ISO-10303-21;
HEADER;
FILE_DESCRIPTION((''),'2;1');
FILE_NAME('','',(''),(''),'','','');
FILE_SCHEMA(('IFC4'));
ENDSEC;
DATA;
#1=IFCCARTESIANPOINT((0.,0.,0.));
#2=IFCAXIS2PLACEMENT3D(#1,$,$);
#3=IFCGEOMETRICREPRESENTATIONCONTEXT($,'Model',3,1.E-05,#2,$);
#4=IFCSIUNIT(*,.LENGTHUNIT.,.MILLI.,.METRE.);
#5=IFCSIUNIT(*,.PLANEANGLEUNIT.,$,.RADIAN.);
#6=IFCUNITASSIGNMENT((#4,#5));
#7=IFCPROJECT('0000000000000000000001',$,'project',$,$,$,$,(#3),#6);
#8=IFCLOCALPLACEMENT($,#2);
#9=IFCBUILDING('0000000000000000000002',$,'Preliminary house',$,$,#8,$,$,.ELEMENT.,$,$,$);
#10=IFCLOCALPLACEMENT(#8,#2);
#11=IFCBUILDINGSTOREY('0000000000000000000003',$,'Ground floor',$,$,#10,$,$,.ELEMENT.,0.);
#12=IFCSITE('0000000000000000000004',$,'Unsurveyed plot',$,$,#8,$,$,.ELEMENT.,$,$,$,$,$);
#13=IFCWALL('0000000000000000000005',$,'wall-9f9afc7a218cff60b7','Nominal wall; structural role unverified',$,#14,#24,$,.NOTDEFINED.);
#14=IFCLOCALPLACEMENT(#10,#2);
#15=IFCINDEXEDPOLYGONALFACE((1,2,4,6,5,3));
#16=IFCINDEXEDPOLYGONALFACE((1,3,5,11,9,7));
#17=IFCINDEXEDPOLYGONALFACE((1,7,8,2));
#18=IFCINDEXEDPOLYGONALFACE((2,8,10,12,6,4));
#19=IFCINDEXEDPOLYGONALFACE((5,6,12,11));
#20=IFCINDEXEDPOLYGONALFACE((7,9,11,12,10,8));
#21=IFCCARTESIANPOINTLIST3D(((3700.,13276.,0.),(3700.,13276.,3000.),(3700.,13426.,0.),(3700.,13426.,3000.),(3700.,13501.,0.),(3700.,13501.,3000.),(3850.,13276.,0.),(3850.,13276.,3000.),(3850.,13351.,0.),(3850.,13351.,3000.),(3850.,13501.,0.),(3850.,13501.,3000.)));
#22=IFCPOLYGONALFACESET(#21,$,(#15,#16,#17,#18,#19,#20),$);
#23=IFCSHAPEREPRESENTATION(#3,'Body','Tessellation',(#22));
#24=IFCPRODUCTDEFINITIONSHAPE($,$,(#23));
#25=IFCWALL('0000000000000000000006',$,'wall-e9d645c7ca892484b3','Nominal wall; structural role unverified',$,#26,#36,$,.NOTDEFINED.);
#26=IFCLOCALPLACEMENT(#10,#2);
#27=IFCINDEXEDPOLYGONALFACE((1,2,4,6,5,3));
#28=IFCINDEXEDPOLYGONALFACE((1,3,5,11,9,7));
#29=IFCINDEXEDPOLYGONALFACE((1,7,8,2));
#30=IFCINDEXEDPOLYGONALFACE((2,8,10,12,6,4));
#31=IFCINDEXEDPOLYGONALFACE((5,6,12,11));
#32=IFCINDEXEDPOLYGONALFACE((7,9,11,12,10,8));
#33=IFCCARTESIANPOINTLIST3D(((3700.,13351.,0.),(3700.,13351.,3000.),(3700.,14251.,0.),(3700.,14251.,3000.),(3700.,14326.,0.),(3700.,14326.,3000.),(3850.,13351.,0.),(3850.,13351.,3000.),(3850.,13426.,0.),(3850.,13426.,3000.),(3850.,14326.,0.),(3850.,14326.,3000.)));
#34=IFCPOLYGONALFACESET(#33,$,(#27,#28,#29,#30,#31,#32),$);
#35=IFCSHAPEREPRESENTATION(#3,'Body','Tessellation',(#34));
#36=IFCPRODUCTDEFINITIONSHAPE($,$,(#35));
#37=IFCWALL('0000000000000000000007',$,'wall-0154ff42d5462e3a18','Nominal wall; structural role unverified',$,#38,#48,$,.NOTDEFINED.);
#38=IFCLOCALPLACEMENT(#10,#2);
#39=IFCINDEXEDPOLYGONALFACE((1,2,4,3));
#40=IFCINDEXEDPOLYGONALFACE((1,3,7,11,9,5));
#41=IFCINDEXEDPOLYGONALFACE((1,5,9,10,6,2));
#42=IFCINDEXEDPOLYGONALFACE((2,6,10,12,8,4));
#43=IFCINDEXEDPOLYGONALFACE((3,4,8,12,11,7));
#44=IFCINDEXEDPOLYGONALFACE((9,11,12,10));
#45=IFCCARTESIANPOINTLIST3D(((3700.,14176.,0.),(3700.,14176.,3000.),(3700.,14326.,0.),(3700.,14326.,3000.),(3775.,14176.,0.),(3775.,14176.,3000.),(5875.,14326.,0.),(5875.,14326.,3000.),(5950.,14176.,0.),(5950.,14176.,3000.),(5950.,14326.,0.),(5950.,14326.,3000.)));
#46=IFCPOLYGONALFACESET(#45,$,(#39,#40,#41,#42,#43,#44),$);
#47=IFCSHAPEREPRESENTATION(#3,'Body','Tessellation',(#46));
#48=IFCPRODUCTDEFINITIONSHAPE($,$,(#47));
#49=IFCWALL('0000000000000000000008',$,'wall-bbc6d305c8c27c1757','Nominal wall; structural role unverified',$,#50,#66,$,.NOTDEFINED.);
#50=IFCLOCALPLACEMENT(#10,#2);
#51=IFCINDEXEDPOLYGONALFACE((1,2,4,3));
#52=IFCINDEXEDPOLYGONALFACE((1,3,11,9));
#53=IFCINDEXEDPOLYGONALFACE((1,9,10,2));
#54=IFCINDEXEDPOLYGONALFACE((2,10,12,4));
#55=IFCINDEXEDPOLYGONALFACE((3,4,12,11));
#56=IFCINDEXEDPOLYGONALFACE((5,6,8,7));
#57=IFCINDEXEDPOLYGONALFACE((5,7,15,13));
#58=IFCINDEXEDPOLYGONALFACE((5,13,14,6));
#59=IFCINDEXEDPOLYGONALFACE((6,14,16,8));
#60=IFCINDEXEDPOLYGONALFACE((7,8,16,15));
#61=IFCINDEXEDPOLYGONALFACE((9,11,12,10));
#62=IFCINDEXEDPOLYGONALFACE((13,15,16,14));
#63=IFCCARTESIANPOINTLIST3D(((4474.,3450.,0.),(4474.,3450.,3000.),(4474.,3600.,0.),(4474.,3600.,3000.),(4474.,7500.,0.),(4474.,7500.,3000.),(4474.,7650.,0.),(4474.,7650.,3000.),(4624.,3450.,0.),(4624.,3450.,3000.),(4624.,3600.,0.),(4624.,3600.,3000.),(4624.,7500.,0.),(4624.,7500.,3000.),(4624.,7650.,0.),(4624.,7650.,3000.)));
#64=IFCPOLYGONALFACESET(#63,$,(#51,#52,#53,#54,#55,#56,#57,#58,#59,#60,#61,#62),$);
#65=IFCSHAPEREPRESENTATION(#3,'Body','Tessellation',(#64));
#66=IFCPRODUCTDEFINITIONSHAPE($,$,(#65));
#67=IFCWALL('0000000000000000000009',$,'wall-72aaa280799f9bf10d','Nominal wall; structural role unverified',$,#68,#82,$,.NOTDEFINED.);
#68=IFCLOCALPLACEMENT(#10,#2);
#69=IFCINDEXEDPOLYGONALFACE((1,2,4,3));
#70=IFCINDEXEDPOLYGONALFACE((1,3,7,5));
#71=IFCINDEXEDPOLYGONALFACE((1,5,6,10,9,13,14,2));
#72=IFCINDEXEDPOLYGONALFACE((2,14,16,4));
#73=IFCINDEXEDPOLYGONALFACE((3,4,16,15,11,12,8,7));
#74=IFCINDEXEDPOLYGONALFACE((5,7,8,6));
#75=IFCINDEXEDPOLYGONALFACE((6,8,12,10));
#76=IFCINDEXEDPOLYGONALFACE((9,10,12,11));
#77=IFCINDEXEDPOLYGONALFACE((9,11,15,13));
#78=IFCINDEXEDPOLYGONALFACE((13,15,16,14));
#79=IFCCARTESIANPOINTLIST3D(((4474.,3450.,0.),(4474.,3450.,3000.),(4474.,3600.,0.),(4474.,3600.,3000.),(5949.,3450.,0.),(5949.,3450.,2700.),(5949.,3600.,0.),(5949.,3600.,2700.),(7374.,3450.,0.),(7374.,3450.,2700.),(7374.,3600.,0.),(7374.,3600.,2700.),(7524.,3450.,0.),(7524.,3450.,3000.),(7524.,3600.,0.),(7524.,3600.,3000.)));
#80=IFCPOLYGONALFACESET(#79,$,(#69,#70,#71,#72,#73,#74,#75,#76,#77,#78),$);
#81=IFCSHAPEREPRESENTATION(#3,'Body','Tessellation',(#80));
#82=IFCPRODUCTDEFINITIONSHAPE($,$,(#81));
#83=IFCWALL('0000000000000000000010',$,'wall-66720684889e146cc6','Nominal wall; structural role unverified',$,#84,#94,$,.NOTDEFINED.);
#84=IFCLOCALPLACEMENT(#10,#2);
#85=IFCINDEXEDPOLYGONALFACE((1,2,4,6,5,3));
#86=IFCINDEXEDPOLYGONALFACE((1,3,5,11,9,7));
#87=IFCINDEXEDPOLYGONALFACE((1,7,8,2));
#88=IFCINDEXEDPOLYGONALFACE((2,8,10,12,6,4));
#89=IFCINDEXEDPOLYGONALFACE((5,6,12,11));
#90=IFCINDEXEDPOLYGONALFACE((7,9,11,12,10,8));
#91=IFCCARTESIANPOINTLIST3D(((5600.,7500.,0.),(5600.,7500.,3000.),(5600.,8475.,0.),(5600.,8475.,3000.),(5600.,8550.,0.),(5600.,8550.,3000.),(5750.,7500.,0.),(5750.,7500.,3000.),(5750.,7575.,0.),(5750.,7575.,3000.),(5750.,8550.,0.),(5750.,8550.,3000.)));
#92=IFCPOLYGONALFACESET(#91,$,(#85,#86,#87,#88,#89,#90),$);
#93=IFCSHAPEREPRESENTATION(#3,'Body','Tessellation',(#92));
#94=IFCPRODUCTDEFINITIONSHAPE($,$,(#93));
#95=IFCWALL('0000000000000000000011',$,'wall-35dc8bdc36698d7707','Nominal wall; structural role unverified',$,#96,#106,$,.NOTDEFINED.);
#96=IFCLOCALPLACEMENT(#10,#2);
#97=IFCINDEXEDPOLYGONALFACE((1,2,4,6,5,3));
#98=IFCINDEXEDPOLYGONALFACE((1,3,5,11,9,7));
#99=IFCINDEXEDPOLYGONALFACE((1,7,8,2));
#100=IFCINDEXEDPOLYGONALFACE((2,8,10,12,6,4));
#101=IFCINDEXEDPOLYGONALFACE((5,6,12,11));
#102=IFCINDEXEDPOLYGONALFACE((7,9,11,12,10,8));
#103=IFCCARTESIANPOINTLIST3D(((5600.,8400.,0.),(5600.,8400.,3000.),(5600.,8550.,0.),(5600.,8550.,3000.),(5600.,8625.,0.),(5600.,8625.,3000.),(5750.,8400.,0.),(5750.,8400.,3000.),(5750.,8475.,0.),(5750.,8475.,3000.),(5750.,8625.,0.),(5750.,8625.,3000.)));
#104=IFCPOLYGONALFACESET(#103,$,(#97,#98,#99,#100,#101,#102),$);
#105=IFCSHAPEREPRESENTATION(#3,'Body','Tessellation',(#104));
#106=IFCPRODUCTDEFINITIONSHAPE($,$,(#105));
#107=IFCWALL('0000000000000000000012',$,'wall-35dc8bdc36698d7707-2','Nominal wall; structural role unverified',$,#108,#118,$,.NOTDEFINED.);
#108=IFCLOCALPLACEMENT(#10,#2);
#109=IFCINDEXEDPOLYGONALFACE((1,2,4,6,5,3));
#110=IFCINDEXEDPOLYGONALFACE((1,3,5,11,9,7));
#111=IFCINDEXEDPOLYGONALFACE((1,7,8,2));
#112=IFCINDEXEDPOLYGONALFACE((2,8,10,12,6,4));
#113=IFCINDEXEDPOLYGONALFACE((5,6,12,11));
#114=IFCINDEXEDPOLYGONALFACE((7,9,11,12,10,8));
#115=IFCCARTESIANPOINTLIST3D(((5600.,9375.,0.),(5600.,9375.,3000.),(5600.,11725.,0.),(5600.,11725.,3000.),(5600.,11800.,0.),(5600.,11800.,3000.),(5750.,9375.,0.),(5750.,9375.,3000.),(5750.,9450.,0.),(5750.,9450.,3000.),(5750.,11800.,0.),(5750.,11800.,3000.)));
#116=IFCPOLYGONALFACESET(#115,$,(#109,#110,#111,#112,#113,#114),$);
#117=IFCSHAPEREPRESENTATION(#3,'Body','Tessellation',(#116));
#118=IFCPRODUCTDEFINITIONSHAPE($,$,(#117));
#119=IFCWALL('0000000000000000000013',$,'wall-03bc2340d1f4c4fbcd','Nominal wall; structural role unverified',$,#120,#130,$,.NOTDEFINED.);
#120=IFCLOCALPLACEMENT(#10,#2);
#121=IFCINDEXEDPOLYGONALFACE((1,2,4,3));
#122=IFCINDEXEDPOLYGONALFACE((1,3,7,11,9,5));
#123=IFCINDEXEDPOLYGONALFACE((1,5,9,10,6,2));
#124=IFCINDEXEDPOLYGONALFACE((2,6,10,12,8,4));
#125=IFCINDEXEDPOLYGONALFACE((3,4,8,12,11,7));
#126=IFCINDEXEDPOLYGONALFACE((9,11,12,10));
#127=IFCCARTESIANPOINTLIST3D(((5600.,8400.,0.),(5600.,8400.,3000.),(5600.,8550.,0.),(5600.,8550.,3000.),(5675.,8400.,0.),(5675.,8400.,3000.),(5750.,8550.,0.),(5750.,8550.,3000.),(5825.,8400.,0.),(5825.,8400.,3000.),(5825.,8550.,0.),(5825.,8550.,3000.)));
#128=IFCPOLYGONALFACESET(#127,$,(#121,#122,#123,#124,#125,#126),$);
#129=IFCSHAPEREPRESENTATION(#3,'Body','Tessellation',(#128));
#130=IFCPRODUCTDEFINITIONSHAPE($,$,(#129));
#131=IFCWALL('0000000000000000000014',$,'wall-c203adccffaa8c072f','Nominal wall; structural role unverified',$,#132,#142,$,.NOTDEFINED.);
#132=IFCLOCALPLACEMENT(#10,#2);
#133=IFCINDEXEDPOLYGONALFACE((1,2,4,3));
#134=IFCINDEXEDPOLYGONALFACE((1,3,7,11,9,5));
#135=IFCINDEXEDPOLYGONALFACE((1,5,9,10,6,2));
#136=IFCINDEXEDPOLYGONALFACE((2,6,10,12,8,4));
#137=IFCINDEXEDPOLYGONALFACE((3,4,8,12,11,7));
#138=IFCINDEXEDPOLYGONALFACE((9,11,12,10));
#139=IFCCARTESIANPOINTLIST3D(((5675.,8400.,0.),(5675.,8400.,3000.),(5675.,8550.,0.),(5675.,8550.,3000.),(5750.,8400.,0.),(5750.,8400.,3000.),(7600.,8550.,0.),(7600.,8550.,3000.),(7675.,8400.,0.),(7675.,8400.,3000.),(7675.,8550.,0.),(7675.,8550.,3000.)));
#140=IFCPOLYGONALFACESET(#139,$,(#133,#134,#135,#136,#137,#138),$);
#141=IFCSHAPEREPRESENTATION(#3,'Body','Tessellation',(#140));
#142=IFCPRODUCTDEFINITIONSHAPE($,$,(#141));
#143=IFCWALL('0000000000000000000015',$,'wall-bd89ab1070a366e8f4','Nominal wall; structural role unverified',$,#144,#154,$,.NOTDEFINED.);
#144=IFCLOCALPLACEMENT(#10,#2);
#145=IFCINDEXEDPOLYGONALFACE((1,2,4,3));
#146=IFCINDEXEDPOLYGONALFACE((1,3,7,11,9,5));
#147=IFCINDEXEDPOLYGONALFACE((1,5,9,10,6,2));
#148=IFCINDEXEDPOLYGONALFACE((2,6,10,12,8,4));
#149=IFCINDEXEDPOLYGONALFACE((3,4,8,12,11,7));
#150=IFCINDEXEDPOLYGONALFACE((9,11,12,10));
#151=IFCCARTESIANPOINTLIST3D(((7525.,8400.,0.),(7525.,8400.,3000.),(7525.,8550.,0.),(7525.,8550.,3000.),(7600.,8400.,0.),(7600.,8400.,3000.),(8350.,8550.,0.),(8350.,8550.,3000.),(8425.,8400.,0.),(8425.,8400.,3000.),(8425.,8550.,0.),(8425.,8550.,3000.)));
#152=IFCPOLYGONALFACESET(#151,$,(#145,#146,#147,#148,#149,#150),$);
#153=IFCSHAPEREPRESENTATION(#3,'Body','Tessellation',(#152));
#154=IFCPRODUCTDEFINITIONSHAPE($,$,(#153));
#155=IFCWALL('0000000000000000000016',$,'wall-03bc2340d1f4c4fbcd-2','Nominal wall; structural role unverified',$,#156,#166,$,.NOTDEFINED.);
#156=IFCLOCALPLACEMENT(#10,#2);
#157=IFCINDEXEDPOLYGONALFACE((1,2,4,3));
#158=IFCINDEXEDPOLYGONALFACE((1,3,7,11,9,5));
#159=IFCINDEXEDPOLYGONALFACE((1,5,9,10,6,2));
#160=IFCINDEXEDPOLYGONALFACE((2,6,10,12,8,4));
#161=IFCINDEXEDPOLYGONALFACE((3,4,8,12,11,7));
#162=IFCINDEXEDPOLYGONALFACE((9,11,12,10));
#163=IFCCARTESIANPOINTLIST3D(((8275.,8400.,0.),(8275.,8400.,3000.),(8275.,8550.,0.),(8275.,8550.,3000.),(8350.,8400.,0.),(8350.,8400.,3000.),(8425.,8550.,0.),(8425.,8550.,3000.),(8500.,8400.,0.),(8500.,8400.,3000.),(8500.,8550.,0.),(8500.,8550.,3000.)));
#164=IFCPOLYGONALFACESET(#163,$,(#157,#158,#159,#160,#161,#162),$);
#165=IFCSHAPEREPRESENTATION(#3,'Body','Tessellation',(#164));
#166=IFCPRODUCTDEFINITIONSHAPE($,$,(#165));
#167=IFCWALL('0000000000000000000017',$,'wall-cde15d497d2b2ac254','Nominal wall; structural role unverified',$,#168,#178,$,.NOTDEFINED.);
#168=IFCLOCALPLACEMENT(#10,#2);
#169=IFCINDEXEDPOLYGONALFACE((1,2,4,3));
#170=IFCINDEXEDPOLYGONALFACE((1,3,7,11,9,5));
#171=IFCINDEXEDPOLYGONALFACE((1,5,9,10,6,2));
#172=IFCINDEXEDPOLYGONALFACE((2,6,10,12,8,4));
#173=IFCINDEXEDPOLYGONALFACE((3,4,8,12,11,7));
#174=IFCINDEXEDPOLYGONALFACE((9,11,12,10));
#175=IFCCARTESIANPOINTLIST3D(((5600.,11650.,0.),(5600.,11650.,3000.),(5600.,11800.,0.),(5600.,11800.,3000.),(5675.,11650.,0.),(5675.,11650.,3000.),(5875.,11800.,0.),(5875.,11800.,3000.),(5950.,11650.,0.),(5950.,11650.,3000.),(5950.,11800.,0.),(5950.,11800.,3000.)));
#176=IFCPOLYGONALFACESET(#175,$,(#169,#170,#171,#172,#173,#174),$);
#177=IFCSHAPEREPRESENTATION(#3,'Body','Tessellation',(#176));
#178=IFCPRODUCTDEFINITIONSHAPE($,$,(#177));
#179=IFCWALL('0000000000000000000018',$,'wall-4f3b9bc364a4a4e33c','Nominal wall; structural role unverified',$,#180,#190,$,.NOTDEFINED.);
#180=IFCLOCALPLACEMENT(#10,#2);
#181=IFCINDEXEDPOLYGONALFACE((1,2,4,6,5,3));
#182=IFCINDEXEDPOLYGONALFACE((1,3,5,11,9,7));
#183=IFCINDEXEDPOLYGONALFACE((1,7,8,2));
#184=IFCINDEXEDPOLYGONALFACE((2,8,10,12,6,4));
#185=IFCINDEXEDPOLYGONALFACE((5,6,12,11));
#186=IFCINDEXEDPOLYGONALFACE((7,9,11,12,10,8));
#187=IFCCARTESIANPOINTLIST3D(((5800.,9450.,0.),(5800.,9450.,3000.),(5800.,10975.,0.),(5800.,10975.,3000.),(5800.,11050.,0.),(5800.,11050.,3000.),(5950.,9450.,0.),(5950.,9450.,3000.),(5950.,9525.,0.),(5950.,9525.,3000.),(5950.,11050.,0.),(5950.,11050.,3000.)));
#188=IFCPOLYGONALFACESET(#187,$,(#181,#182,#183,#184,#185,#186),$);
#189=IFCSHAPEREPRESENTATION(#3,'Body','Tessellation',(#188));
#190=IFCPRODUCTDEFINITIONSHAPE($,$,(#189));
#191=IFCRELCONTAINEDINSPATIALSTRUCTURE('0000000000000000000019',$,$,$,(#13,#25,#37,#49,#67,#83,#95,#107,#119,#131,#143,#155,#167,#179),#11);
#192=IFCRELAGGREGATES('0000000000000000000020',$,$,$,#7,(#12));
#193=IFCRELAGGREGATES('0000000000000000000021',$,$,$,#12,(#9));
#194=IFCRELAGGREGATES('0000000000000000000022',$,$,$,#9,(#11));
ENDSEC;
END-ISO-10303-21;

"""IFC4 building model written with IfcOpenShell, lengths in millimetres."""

from ifc_helpers import new_model, si_unit, origin, place, context, project, spatial, polyline, outline, extrude, element, save


model = new_model("IFC4")

# Units and contexts
model_context = context("Model", 3, precision=1e-05, world=origin())
ifc_project = project(units=[si_unit("LENGTHUNIT", "METRE", prefix="MILLI"), si_unit("PLANEANGLEUNIT", "RADIAN")], contexts=[model_context])

# Site, building, storey
placement_1 = place(None, origin())
site = spatial("IfcSite", under=ifc_project, at=placement_1, Name="Unsurveyed plot", CompositionType="ELEMENT")
building = spatial("IfcBuilding", under=site, at=placement_1, Name="Preliminary house", CompositionType="ELEMENT")
placement_2 = place(placement_1, origin())
storey = spatial("IfcBuildingStorey", under=building, at=placement_2, Name="Ground floor", CompositionType="ELEMENT", Elevation=0.0)

# Walls
element("IfcWall", 1, at=placement_2, inside=storey, Name="wall-9f9afc7a218cff60b7", Description="Nominal wall; structural role unverified", PredefinedType="NOTDEFINED", context=model_context, shape_type="SweptSolid", body=[
    extrude(outline(polyline([(3700.0, 13426.0), (3700.0, 13501.0), (3850.0, 13501.0), (3850.0, 13351.0), (3850.0, 13276.0), (3700.0, 13276.0), (3700.0, 13426.0)])), origin(), (0.0, 0.0, 1.0), 3000.0),
])
element("IfcWall", 2, at=placement_2, inside=storey, Name="wall-e9d645c7ca892484b3", Description="Nominal wall; structural role unverified", PredefinedType="NOTDEFINED", context=model_context, shape_type="SweptSolid", body=[
    extrude(outline(polyline([(3700.0, 14251.0), (3700.0, 14326.0), (3850.0, 14326.0), (3850.0, 13426.0), (3850.0, 13351.0), (3700.0, 13351.0), (3700.0, 14251.0)])), origin(), (0.0, 0.0, 1.0), 3000.0),
])
element("IfcWall", 3, at=placement_2, inside=storey, Name="wall-0154ff42d5462e3a18", Description="Nominal wall; structural role unverified", PredefinedType="NOTDEFINED", context=model_context, shape_type="SweptSolid", body=[
    extrude(outline(polyline([(5875.0, 14326.0), (5950.0, 14326.0), (5950.0, 14176.0), (3775.0, 14176.0), (3700.0, 14176.0), (3700.0, 14326.0), (5875.0, 14326.0)])), origin(), (0.0, 0.0, 1.0), 3000.0),
])

# Walls, openings
wall_1 = element("IfcWall", 4, at=placement_2, inside=storey, Name="wall-bbc6d305c8c27c1757", Description="Nominal wall; structural role unverified", PredefinedType="NOTDEFINED", context=model_context, shape_type="SweptSolid", body=[
    extrude(outline(polyline([(4474.0, 7575.0), (4474.0, 7650.0), (4624.0, 7650.0), (4624.0, 3525.0), (4624.0, 3450.0), (4474.0, 3450.0), (4474.0, 7575.0)])), origin(), (0.0, 0.0, 1.0), 3000.0),
])
element("IfcOpeningElement", 5, at=placement_2, cuts=wall_1, PredefinedType="OPENING", context=model_context, shape_type="SweptSolid", body=[
    extrude(outline(polyline([(4999.0, 3600.0), (4999.0, 7500.0), (4099.0, 7500.0), (4099.0, 3600.0), (4999.0, 3600.0)])), origin(), (0.0, 0.0, 1.0), 3000.0),
])
wall_2 = element("IfcWall", 6, at=placement_2, inside=storey, Name="wall-72aaa280799f9bf10d", Description="Nominal wall; structural role unverified", PredefinedType="NOTDEFINED", context=model_context, shape_type="SweptSolid", body=[
    extrude(outline(polyline([(7449.0, 3600.0), (7524.0, 3600.0), (7524.0, 3450.0), (4549.0, 3450.0), (4474.0, 3450.0), (4474.0, 3600.0), (7449.0, 3600.0)])), origin(), (0.0, 0.0, 1.0), 3000.0),
])
element("IfcOpeningElement", 7, at=placement_2, cuts=wall_2, PredefinedType="OPENING", context=model_context, shape_type="SweptSolid", body=[
    extrude(outline(polyline([(5949.0, 3075.0), (7374.0, 3075.0), (7374.0, 3975.0), (5949.0, 3975.0), (5949.0, 3075.0)])), origin(), (0.0, 0.0, 1.0), 2700.0),
])

# Walls
element("IfcWall", 8, at=placement_2, inside=storey, Name="wall-66720684889e146cc6", Description="Nominal wall; structural role unverified", PredefinedType="NOTDEFINED", context=model_context, shape_type="SweptSolid", body=[
    extrude(outline(polyline([(5600.0, 8475.0), (5600.0, 8550.0), (5750.0, 8550.0), (5750.0, 7575.0), (5750.0, 7500.0), (5600.0, 7500.0), (5600.0, 8475.0)])), origin(), (0.0, 0.0, 1.0), 3000.0),
])
element("IfcWall", 9, at=placement_2, inside=storey, Name="wall-35dc8bdc36698d7707", Description="Nominal wall; structural role unverified", PredefinedType="NOTDEFINED", context=model_context, shape_type="SweptSolid", body=[
    extrude(outline(polyline([(5600.0, 8550.0), (5600.0, 8625.0), (5750.0, 8625.0), (5750.0, 8475.0), (5750.0, 8400.0), (5600.0, 8400.0), (5600.0, 8550.0)])), origin(), (0.0, 0.0, 1.0), 3000.0),
])

# Walls
element("IfcWall", 10, at=placement_2, inside=storey, Name="wall-35dc8bdc36698d7707-2", Description="Nominal wall; structural role unverified", PredefinedType="NOTDEFINED", context=model_context, shape_type="SweptSolid", body=[
    extrude(outline(polyline([(5600.0, 11725.0), (5600.0, 11800.0), (5750.0, 11800.0), (5750.0, 9450.0), (5750.0, 9375.0), (5600.0, 9375.0), (5600.0, 11725.0)])), origin(), (0.0, 0.0, 1.0), 3000.0),
])
element("IfcWall", 11, at=placement_2, inside=storey, Name="wall-03bc2340d1f4c4fbcd", Description="Nominal wall; structural role unverified", PredefinedType="NOTDEFINED", context=model_context, shape_type="SweptSolid", body=[
    extrude(outline(polyline([(5750.0, 8550.0), (5825.0, 8550.0), (5825.0, 8400.0), (5675.0, 8400.0), (5600.0, 8400.0), (5600.0, 8550.0), (5750.0, 8550.0)])), origin(), (0.0, 0.0, 1.0), 3000.0),
])
element("IfcWall", 12, at=placement_2, inside=storey, Name="wall-c203adccffaa8c072f", Description="Nominal wall; structural role unverified", PredefinedType="NOTDEFINED", context=model_context, shape_type="SweptSolid", body=[
    extrude(outline(polyline([(7600.0, 8550.0), (7675.0, 8550.0), (7675.0, 8400.0), (5750.0, 8400.0), (5675.0, 8400.0), (5675.0, 8550.0), (7600.0, 8550.0)])), origin(), (0.0, 0.0, 1.0), 3000.0),
])
element("IfcWall", 13, at=placement_2, inside=storey, Name="wall-bd89ab1070a366e8f4", Description="Nominal wall; structural role unverified", PredefinedType="NOTDEFINED", context=model_context, shape_type="SweptSolid", body=[
    extrude(outline(polyline([(8350.0, 8550.0), (8425.0, 8550.0), (8425.0, 8400.0), (7600.0, 8400.0), (7525.0, 8400.0), (7525.0, 8550.0), (8350.0, 8550.0)])), origin(), (0.0, 0.0, 1.0), 3000.0),
])
element("IfcWall", 14, at=placement_2, inside=storey, Name="wall-03bc2340d1f4c4fbcd-2", Description="Nominal wall; structural role unverified", PredefinedType="NOTDEFINED", context=model_context, shape_type="SweptSolid", body=[
    extrude(outline(polyline([(8425.0, 8550.0), (8500.0, 8550.0), (8500.0, 8400.0), (8350.0, 8400.0), (8275.0, 8400.0), (8275.0, 8550.0), (8425.0, 8550.0)])), origin(), (0.0, 0.0, 1.0), 3000.0),
])
element("IfcWall", 15, at=placement_2, inside=storey, Name="wall-cde15d497d2b2ac254", Description="Nominal wall; structural role unverified", PredefinedType="NOTDEFINED", context=model_context, shape_type="SweptSolid", body=[
    extrude(outline(polyline([(5875.0, 11800.0), (5950.0, 11800.0), (5950.0, 11650.0), (5675.0, 11650.0), (5600.0, 11650.0), (5600.0, 11800.0), (5875.0, 11800.0)])), origin(), (0.0, 0.0, 1.0), 3000.0),
])
element("IfcWall", 16, at=placement_2, inside=storey, Name="wall-4f3b9bc364a4a4e33c", Description="Nominal wall; structural role unverified", PredefinedType="NOTDEFINED", context=model_context, shape_type="SweptSolid", body=[
    extrude(outline(polyline([(5800.0, 10975.0), (5800.0, 11050.0), (5950.0, 11050.0), (5950.0, 9525.0), (5950.0, 9450.0), (5800.0, 9450.0), (5800.0, 10975.0)])), origin(), (0.0, 0.0, 1.0), 3000.0),
])

save(model, "model.ifc")
